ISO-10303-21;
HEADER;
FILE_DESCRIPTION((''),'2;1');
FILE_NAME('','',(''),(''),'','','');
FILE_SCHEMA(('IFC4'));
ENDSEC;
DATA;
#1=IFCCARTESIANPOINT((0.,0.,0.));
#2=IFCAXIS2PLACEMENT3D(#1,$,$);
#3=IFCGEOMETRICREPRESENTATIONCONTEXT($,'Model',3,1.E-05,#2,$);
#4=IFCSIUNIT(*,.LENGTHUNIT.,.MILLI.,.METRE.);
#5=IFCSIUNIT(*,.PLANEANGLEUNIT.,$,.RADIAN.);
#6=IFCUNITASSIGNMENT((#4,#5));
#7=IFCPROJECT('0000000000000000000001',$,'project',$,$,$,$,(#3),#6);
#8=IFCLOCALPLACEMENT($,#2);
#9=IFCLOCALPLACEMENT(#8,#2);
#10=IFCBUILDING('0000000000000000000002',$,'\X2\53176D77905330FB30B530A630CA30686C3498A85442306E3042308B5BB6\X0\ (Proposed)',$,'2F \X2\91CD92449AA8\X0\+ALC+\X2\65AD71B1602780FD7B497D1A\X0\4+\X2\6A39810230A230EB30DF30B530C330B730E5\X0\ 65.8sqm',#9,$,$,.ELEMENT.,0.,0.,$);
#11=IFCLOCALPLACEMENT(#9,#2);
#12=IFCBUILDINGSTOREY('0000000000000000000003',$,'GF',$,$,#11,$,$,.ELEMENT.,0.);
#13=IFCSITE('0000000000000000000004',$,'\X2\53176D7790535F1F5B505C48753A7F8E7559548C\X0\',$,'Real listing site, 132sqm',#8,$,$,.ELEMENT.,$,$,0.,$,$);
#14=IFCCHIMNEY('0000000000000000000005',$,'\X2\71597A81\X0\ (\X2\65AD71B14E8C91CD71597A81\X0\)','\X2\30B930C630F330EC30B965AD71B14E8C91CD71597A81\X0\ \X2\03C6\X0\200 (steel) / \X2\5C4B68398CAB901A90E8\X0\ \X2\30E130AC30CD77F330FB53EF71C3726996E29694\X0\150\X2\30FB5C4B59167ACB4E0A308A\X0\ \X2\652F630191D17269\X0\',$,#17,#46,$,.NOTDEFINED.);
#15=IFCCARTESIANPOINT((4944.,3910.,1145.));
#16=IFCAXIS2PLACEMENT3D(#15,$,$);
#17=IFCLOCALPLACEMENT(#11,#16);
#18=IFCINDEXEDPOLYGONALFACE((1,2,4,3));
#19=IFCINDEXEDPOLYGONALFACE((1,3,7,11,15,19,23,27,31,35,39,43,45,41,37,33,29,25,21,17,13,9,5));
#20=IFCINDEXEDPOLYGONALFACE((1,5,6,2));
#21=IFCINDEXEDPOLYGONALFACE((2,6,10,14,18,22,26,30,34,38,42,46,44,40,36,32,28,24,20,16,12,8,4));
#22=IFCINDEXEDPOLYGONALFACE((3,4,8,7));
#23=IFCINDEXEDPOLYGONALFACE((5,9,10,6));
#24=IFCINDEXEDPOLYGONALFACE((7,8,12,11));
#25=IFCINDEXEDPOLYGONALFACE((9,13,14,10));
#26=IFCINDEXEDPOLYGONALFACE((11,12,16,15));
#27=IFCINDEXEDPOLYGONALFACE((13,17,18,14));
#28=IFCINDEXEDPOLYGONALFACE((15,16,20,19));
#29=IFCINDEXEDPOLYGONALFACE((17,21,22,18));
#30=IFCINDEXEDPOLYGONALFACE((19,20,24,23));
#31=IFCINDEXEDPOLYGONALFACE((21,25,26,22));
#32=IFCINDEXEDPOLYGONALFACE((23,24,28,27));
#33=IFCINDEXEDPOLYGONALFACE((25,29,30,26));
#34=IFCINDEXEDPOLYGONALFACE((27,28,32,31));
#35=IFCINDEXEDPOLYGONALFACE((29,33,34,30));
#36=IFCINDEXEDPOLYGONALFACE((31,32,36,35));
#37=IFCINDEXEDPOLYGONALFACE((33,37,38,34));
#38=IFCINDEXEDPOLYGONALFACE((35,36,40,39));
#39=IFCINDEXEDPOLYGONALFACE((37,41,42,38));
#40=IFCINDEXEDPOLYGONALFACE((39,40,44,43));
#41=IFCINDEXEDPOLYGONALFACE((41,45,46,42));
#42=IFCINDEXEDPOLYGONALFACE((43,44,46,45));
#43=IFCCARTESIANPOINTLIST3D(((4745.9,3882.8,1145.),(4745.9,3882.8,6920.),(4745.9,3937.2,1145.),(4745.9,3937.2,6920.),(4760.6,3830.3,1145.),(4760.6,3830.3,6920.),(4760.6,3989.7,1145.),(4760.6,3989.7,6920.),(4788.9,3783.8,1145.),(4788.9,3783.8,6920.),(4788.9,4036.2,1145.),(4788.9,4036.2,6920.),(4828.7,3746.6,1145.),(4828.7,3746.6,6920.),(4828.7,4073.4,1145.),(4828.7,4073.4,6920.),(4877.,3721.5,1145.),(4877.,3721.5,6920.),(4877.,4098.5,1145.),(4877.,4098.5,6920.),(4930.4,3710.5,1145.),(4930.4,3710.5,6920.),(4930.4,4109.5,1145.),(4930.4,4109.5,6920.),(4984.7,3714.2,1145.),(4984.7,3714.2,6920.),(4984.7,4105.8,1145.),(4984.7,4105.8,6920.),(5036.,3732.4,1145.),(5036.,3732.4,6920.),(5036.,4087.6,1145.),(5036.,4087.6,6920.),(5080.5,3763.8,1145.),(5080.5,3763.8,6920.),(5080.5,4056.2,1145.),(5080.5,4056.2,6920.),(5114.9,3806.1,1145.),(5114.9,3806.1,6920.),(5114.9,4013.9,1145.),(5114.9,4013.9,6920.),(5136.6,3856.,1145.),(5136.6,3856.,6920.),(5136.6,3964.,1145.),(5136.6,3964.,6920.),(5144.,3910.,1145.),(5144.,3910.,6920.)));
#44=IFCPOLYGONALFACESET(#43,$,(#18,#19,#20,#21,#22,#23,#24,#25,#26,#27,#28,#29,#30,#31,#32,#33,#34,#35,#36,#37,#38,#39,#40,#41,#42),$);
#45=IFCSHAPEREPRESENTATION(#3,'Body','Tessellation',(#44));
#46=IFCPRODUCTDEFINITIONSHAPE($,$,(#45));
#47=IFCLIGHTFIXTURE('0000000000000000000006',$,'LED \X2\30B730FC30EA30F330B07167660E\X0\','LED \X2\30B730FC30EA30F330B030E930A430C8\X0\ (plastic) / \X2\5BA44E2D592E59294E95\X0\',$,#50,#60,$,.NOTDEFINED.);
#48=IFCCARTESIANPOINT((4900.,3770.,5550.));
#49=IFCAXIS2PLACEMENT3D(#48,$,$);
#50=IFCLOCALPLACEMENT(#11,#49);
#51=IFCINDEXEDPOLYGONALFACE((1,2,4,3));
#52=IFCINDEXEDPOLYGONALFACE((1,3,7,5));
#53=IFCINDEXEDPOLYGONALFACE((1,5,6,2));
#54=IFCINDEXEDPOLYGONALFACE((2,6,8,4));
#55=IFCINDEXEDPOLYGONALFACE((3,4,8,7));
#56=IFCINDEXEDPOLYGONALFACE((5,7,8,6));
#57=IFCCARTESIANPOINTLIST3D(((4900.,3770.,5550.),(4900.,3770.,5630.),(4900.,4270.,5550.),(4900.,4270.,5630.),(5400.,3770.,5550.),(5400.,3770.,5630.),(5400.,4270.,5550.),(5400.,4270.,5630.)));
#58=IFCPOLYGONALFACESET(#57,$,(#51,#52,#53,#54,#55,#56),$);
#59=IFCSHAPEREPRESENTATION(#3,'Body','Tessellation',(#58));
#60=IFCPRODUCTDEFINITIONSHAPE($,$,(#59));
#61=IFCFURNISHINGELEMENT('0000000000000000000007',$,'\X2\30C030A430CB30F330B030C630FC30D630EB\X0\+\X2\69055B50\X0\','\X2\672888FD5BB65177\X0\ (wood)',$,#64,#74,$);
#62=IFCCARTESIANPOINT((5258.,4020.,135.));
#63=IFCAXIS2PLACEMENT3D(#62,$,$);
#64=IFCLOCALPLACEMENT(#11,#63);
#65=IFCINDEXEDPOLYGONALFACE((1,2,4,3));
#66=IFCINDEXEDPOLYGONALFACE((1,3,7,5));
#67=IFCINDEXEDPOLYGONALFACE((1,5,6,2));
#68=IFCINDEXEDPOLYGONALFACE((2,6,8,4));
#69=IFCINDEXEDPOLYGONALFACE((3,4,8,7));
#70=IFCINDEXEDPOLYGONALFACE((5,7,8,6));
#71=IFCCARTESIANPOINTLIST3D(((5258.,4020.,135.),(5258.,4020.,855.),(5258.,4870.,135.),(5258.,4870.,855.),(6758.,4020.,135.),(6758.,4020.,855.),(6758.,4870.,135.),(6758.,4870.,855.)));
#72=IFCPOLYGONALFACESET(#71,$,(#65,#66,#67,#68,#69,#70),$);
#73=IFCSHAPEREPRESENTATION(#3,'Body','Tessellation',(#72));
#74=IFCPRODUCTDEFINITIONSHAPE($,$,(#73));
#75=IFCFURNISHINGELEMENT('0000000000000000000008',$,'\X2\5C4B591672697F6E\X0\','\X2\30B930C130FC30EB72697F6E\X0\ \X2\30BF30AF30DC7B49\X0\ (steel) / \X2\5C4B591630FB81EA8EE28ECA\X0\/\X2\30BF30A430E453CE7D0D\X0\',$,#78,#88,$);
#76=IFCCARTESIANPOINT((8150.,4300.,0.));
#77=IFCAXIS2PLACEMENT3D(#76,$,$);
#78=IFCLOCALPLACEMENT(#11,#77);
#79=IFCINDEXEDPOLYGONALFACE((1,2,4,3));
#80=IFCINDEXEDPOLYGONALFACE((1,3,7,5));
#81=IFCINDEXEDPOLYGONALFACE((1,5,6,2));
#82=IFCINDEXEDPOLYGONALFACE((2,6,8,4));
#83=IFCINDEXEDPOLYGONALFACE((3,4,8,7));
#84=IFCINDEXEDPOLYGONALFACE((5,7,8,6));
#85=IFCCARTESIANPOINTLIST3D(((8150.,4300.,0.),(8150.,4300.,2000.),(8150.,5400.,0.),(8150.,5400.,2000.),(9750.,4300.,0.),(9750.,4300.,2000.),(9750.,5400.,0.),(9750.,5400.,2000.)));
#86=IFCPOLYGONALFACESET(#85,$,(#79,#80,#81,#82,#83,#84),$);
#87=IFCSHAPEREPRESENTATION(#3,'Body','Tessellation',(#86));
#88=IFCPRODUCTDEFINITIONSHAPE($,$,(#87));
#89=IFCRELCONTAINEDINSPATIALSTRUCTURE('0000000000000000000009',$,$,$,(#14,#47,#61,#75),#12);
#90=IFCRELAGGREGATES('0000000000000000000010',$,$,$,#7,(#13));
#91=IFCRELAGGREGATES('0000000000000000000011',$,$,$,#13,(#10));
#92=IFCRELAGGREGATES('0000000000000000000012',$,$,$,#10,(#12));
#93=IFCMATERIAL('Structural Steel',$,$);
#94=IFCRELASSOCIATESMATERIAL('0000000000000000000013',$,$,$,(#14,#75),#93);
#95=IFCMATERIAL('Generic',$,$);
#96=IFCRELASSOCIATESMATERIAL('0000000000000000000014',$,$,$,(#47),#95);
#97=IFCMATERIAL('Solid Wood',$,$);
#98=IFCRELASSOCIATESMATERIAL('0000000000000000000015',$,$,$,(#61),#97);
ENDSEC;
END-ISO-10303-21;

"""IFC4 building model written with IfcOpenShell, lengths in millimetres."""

from ifc_helpers import new_model, si_unit, frame, frame_2d, origin, origin_2d, place, context, project, spatial, rectangle, circle, extrude, material, element, save


model = new_model("IFC4")

# Units and contexts
model_context = context("Model", 3, precision=1e-05, world=origin())
ifc_project = project(units=[si_unit("LENGTHUNIT", "METRE", prefix="MILLI"), si_unit("PLANEANGLEUNIT", "RADIAN")], contexts=[model_context])

# Site, building, storey
site_placement = place(None, origin())
site = spatial("IfcSite", under=ifc_project, at=site_placement, Name="北海道弟子屈町美留和", ObjectType="Real listing site, 132sqm", CompositionType="ELEMENT", RefElevation=0.0)
building_placement = place(site_placement, origin())
building = spatial("IfcBuilding", under=site, at=building_placement, Name="北海道・サウナと水風呂のある家 (Proposed)", ObjectType="2F 重鉄骨+ALC+断熱性能等級4+樹脂アルミサッシュ 65.8sqm", CompositionType="ELEMENT", ElevationOfRefHeight=0.0, ElevationOfTerrain=0.0)
storey_placement = place(building_placement, origin())
storey = spatial("IfcBuildingStorey", under=building, at=storey_placement, Name="GF", CompositionType="ELEMENT", Elevation=0.0)

# Shared definitions
ifc_material_1 = material(Name="Solid Wood")

# Shared definitions
ifc_material_2 = material(Name="Structural Steel")

# Chimney
chimney_placement = place(storey_placement, frame((4944.0, 3910.0, 1145.0)))
element("IfcChimney", 1, at=chimney_placement, inside=storey, material=ifc_material_2, Name="煙突 (断熱二重煙突)", Description="ステンレス断熱二重煙突 φ200 (steel) / 屋根貫通部 メガネ石・可燃物離隔150・屋外立上り 支持金物", PredefinedType="NOTDEFINED", context=model_context, shape_type="SweptSolid", body=[
    extrude(circle(Radius=200.0, at=origin_2d()), frame((4944.0, 3910.0, 1145.0)), (0.0, 0.0, 1.0), 5775.0),
])

# Light fixture
ifc_material_3 = material(Name="Generic")
light_fixture_placement = place(storey_placement, frame((4900.0, 3770.0, 5550.0)))
element("IfcLightFixture", 2, at=light_fixture_placement, inside=storey, material=ifc_material_3, Name="LED シーリング照明", Description="LED シーリングライト (plastic) / 室中央天井", PredefinedType="NOTDEFINED", context=model_context, shape_type="SweptSolid", body=[
    extrude(rectangle(XDim=500.0, YDim=500.0, at=frame_2d((250.0, 250.0))), frame((4900.0, 3770.0, 5550.0)), (0.0, 0.0, 1.0), 80.0),
])

# Furnishing elements
furnishing_1_placement = place(storey_placement, frame((5258.0, 4020.0, 135.0)))
element("IfcFurnishingElement", 3, at=furnishing_1_placement, inside=storey, material=ifc_material_1, Name="ダイニングテーブル+椅子", Description="木製家具 (wood)", context=model_context, shape_type="SweptSolid", body=[
    extrude(rectangle(XDim=1500.0, YDim=850.0, at=frame_2d((750.0, 425.0))), frame((5258.0, 4020.0, 135.0)), (0.0, 0.0, 1.0), 720.0),
])
furnishing_2_placement = place(storey_placement, frame((8150.0, 4300.0, 0.0)))
element("IfcFurnishingElement", 4, at=furnishing_2_placement, inside=storey, material=ifc_material_2, Name="屋外物置", Description="スチール物置 タクボ等 (steel) / 屋外・自転車/タイヤ収納", context=model_context, shape_type="SweptSolid", body=[
    extrude(rectangle(XDim=1600.0, YDim=1100.0, at=frame_2d((800.0, 550.0))), frame((8150.0, 4300.0, 0.0)), (0.0, 0.0, 1.0), 2000.0),
])

save(model, "model.ifc")
